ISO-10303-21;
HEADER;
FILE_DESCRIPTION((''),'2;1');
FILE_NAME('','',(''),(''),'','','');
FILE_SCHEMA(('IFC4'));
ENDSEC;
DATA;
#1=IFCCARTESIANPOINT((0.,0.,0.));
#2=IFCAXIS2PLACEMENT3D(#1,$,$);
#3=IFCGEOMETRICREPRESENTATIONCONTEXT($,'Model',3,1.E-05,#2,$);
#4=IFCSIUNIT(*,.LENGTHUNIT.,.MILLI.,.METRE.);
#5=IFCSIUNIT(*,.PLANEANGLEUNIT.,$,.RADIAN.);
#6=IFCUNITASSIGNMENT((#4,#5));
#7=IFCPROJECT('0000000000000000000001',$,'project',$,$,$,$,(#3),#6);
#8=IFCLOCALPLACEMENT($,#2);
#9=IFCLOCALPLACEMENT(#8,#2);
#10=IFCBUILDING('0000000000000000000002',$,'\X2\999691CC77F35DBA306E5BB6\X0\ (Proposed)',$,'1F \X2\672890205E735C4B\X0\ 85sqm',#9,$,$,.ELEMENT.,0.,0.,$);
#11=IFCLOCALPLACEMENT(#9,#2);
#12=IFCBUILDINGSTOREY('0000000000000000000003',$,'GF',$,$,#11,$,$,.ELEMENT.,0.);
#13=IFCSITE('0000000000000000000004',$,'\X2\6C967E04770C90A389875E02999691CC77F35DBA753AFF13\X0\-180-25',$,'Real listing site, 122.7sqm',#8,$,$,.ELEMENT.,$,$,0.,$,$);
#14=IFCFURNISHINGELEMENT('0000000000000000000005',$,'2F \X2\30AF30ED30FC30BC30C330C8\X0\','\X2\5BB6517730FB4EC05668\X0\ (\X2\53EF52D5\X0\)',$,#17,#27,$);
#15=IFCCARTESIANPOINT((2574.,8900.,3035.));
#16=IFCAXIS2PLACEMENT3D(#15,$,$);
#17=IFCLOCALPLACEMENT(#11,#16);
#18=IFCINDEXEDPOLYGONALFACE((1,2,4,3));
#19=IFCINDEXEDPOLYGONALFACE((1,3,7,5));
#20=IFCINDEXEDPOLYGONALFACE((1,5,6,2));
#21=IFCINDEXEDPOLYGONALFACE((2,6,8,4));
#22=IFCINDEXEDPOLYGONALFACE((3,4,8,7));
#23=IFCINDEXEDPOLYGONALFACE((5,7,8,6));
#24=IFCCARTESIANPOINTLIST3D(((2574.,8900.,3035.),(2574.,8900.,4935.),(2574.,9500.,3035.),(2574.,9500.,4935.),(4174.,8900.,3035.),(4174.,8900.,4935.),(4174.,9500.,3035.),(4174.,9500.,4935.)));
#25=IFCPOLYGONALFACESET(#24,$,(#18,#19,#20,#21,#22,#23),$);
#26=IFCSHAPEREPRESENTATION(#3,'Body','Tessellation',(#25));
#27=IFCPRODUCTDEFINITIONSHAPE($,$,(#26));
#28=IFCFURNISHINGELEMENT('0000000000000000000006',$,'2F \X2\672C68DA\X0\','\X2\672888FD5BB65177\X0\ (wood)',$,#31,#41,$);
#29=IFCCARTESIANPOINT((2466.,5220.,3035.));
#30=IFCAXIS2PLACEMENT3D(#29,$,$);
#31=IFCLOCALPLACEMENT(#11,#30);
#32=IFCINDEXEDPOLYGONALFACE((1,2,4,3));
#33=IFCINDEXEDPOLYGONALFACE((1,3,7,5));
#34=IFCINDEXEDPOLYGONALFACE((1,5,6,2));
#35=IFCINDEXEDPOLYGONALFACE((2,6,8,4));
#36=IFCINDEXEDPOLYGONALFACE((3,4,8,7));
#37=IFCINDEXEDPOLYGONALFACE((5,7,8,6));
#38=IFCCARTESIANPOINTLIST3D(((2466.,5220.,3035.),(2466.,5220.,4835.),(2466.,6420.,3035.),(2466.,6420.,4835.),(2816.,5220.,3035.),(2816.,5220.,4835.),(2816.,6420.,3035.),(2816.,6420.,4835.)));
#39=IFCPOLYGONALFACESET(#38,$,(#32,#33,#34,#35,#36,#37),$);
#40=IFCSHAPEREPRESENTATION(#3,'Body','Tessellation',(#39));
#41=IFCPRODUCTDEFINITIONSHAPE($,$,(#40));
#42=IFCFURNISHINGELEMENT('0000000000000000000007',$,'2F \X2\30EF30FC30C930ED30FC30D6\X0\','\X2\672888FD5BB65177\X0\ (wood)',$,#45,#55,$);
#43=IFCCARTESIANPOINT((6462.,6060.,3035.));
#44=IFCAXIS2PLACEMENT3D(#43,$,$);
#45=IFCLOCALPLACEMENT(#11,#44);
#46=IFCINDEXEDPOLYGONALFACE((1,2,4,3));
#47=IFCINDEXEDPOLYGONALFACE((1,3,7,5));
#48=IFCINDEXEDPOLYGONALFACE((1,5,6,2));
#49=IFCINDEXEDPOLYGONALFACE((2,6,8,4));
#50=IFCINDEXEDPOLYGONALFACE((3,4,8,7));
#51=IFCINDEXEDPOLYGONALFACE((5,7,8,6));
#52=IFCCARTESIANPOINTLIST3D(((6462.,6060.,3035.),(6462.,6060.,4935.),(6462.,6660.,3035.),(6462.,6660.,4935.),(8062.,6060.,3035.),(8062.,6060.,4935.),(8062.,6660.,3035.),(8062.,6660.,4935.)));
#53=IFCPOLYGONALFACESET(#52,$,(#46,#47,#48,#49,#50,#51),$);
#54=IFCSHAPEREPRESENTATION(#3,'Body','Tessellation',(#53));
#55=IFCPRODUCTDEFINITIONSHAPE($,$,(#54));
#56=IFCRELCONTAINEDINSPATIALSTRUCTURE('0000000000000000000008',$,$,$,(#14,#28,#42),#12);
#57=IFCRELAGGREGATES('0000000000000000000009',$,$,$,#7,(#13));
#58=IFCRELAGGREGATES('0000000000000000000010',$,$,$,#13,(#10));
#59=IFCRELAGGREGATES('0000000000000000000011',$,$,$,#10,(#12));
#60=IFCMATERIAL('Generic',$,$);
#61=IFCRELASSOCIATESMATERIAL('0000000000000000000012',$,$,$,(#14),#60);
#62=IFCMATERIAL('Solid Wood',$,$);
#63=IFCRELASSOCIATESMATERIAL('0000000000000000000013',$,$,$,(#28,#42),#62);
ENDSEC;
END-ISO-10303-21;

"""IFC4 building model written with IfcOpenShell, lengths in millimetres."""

from ifc_helpers import new_model, si_unit, frame, frame_2d, origin, place, context, project, spatial, rectangle, extrude, material, element, save


model = new_model("IFC4")

# Units and contexts
model_context = context("Model", 3, precision=1e-05, world=origin())
ifc_project = project(units=[si_unit("LENGTHUNIT", "METRE", prefix="MILLI"), si_unit("PLANEANGLEUNIT", "RADIAN")], contexts=[model_context])

# Site, building, storey
site_placement = place(None, origin())
site = spatial("IfcSite", under=ifc_project, at=site_placement, Name="沖縄県那覇市首里石嶺町３-180-25", ObjectType="Real listing site, 122.7sqm", CompositionType="ELEMENT", RefElevation=0.0)
building_placement = place(site_placement, origin())
building = spatial("IfcBuilding", under=site, at=building_placement, Name="首里石嶺の家 (Proposed)", ObjectType="1F 木造平屋 85sqm", CompositionType="ELEMENT", ElevationOfRefHeight=0.0, ElevationOfTerrain=0.0)
storey_placement = place(building_placement, origin())
storey = spatial("IfcBuildingStorey", under=building, at=storey_placement, Name="GF", CompositionType="ELEMENT", Elevation=0.0)

# Shared definitions
ifc_material_1 = material(Name="Solid Wood")

# Shared definitions
ifc_material_2 = material(Name="Generic")

# Furnishing elements
furnishing_1_placement = place(storey_placement, frame((2574.0, 8900.0, 3035.0)))
element("IfcFurnishingElement", 1, at=furnishing_1_placement, inside=storey, material=ifc_material_2, Name="2F クローゼット", Description="家具・什器 (可動)", context=model_context, shape_type="SweptSolid", body=[
    extrude(rectangle(XDim=1600.0, YDim=600.0, at=frame_2d((800.0, 300.0))), frame((2574.0, 8900.0, 3035.0)), (0.0, 0.0, 1.0), 1900.0),
])
furnishing_2_placement = place(storey_placement, frame((2466.0, 5220.0, 3035.0)))
element("IfcFurnishingElement", 2, at=furnishing_2_placement, inside=storey, material=ifc_material_1, Name="2F 本棚", Description="木製家具 (wood)", context=model_context, shape_type="SweptSolid", body=[
    extrude(rectangle(XDim=350.0, YDim=1200.0, at=frame_2d((175.0, 600.0))), frame((2466.0, 5220.0, 3035.0)), (0.0, 0.0, 1.0), 1800.0),
])
furnishing_3_placement = place(storey_placement, frame((6462.0, 6060.0, 3035.0)))
element("IfcFurnishingElement", 3, at=furnishing_3_placement, inside=storey, material=ifc_material_1, Name="2F ワードローブ", Description="木製家具 (wood)", context=model_context, shape_type="SweptSolid", body=[
    extrude(rectangle(XDim=1600.0, YDim=600.0, at=frame_2d((800.0, 300.0))), frame((6462.0, 6060.0, 3035.0)), (0.0, 0.0, 1.0), 1900.0),
])

save(model, "model.ifc")
